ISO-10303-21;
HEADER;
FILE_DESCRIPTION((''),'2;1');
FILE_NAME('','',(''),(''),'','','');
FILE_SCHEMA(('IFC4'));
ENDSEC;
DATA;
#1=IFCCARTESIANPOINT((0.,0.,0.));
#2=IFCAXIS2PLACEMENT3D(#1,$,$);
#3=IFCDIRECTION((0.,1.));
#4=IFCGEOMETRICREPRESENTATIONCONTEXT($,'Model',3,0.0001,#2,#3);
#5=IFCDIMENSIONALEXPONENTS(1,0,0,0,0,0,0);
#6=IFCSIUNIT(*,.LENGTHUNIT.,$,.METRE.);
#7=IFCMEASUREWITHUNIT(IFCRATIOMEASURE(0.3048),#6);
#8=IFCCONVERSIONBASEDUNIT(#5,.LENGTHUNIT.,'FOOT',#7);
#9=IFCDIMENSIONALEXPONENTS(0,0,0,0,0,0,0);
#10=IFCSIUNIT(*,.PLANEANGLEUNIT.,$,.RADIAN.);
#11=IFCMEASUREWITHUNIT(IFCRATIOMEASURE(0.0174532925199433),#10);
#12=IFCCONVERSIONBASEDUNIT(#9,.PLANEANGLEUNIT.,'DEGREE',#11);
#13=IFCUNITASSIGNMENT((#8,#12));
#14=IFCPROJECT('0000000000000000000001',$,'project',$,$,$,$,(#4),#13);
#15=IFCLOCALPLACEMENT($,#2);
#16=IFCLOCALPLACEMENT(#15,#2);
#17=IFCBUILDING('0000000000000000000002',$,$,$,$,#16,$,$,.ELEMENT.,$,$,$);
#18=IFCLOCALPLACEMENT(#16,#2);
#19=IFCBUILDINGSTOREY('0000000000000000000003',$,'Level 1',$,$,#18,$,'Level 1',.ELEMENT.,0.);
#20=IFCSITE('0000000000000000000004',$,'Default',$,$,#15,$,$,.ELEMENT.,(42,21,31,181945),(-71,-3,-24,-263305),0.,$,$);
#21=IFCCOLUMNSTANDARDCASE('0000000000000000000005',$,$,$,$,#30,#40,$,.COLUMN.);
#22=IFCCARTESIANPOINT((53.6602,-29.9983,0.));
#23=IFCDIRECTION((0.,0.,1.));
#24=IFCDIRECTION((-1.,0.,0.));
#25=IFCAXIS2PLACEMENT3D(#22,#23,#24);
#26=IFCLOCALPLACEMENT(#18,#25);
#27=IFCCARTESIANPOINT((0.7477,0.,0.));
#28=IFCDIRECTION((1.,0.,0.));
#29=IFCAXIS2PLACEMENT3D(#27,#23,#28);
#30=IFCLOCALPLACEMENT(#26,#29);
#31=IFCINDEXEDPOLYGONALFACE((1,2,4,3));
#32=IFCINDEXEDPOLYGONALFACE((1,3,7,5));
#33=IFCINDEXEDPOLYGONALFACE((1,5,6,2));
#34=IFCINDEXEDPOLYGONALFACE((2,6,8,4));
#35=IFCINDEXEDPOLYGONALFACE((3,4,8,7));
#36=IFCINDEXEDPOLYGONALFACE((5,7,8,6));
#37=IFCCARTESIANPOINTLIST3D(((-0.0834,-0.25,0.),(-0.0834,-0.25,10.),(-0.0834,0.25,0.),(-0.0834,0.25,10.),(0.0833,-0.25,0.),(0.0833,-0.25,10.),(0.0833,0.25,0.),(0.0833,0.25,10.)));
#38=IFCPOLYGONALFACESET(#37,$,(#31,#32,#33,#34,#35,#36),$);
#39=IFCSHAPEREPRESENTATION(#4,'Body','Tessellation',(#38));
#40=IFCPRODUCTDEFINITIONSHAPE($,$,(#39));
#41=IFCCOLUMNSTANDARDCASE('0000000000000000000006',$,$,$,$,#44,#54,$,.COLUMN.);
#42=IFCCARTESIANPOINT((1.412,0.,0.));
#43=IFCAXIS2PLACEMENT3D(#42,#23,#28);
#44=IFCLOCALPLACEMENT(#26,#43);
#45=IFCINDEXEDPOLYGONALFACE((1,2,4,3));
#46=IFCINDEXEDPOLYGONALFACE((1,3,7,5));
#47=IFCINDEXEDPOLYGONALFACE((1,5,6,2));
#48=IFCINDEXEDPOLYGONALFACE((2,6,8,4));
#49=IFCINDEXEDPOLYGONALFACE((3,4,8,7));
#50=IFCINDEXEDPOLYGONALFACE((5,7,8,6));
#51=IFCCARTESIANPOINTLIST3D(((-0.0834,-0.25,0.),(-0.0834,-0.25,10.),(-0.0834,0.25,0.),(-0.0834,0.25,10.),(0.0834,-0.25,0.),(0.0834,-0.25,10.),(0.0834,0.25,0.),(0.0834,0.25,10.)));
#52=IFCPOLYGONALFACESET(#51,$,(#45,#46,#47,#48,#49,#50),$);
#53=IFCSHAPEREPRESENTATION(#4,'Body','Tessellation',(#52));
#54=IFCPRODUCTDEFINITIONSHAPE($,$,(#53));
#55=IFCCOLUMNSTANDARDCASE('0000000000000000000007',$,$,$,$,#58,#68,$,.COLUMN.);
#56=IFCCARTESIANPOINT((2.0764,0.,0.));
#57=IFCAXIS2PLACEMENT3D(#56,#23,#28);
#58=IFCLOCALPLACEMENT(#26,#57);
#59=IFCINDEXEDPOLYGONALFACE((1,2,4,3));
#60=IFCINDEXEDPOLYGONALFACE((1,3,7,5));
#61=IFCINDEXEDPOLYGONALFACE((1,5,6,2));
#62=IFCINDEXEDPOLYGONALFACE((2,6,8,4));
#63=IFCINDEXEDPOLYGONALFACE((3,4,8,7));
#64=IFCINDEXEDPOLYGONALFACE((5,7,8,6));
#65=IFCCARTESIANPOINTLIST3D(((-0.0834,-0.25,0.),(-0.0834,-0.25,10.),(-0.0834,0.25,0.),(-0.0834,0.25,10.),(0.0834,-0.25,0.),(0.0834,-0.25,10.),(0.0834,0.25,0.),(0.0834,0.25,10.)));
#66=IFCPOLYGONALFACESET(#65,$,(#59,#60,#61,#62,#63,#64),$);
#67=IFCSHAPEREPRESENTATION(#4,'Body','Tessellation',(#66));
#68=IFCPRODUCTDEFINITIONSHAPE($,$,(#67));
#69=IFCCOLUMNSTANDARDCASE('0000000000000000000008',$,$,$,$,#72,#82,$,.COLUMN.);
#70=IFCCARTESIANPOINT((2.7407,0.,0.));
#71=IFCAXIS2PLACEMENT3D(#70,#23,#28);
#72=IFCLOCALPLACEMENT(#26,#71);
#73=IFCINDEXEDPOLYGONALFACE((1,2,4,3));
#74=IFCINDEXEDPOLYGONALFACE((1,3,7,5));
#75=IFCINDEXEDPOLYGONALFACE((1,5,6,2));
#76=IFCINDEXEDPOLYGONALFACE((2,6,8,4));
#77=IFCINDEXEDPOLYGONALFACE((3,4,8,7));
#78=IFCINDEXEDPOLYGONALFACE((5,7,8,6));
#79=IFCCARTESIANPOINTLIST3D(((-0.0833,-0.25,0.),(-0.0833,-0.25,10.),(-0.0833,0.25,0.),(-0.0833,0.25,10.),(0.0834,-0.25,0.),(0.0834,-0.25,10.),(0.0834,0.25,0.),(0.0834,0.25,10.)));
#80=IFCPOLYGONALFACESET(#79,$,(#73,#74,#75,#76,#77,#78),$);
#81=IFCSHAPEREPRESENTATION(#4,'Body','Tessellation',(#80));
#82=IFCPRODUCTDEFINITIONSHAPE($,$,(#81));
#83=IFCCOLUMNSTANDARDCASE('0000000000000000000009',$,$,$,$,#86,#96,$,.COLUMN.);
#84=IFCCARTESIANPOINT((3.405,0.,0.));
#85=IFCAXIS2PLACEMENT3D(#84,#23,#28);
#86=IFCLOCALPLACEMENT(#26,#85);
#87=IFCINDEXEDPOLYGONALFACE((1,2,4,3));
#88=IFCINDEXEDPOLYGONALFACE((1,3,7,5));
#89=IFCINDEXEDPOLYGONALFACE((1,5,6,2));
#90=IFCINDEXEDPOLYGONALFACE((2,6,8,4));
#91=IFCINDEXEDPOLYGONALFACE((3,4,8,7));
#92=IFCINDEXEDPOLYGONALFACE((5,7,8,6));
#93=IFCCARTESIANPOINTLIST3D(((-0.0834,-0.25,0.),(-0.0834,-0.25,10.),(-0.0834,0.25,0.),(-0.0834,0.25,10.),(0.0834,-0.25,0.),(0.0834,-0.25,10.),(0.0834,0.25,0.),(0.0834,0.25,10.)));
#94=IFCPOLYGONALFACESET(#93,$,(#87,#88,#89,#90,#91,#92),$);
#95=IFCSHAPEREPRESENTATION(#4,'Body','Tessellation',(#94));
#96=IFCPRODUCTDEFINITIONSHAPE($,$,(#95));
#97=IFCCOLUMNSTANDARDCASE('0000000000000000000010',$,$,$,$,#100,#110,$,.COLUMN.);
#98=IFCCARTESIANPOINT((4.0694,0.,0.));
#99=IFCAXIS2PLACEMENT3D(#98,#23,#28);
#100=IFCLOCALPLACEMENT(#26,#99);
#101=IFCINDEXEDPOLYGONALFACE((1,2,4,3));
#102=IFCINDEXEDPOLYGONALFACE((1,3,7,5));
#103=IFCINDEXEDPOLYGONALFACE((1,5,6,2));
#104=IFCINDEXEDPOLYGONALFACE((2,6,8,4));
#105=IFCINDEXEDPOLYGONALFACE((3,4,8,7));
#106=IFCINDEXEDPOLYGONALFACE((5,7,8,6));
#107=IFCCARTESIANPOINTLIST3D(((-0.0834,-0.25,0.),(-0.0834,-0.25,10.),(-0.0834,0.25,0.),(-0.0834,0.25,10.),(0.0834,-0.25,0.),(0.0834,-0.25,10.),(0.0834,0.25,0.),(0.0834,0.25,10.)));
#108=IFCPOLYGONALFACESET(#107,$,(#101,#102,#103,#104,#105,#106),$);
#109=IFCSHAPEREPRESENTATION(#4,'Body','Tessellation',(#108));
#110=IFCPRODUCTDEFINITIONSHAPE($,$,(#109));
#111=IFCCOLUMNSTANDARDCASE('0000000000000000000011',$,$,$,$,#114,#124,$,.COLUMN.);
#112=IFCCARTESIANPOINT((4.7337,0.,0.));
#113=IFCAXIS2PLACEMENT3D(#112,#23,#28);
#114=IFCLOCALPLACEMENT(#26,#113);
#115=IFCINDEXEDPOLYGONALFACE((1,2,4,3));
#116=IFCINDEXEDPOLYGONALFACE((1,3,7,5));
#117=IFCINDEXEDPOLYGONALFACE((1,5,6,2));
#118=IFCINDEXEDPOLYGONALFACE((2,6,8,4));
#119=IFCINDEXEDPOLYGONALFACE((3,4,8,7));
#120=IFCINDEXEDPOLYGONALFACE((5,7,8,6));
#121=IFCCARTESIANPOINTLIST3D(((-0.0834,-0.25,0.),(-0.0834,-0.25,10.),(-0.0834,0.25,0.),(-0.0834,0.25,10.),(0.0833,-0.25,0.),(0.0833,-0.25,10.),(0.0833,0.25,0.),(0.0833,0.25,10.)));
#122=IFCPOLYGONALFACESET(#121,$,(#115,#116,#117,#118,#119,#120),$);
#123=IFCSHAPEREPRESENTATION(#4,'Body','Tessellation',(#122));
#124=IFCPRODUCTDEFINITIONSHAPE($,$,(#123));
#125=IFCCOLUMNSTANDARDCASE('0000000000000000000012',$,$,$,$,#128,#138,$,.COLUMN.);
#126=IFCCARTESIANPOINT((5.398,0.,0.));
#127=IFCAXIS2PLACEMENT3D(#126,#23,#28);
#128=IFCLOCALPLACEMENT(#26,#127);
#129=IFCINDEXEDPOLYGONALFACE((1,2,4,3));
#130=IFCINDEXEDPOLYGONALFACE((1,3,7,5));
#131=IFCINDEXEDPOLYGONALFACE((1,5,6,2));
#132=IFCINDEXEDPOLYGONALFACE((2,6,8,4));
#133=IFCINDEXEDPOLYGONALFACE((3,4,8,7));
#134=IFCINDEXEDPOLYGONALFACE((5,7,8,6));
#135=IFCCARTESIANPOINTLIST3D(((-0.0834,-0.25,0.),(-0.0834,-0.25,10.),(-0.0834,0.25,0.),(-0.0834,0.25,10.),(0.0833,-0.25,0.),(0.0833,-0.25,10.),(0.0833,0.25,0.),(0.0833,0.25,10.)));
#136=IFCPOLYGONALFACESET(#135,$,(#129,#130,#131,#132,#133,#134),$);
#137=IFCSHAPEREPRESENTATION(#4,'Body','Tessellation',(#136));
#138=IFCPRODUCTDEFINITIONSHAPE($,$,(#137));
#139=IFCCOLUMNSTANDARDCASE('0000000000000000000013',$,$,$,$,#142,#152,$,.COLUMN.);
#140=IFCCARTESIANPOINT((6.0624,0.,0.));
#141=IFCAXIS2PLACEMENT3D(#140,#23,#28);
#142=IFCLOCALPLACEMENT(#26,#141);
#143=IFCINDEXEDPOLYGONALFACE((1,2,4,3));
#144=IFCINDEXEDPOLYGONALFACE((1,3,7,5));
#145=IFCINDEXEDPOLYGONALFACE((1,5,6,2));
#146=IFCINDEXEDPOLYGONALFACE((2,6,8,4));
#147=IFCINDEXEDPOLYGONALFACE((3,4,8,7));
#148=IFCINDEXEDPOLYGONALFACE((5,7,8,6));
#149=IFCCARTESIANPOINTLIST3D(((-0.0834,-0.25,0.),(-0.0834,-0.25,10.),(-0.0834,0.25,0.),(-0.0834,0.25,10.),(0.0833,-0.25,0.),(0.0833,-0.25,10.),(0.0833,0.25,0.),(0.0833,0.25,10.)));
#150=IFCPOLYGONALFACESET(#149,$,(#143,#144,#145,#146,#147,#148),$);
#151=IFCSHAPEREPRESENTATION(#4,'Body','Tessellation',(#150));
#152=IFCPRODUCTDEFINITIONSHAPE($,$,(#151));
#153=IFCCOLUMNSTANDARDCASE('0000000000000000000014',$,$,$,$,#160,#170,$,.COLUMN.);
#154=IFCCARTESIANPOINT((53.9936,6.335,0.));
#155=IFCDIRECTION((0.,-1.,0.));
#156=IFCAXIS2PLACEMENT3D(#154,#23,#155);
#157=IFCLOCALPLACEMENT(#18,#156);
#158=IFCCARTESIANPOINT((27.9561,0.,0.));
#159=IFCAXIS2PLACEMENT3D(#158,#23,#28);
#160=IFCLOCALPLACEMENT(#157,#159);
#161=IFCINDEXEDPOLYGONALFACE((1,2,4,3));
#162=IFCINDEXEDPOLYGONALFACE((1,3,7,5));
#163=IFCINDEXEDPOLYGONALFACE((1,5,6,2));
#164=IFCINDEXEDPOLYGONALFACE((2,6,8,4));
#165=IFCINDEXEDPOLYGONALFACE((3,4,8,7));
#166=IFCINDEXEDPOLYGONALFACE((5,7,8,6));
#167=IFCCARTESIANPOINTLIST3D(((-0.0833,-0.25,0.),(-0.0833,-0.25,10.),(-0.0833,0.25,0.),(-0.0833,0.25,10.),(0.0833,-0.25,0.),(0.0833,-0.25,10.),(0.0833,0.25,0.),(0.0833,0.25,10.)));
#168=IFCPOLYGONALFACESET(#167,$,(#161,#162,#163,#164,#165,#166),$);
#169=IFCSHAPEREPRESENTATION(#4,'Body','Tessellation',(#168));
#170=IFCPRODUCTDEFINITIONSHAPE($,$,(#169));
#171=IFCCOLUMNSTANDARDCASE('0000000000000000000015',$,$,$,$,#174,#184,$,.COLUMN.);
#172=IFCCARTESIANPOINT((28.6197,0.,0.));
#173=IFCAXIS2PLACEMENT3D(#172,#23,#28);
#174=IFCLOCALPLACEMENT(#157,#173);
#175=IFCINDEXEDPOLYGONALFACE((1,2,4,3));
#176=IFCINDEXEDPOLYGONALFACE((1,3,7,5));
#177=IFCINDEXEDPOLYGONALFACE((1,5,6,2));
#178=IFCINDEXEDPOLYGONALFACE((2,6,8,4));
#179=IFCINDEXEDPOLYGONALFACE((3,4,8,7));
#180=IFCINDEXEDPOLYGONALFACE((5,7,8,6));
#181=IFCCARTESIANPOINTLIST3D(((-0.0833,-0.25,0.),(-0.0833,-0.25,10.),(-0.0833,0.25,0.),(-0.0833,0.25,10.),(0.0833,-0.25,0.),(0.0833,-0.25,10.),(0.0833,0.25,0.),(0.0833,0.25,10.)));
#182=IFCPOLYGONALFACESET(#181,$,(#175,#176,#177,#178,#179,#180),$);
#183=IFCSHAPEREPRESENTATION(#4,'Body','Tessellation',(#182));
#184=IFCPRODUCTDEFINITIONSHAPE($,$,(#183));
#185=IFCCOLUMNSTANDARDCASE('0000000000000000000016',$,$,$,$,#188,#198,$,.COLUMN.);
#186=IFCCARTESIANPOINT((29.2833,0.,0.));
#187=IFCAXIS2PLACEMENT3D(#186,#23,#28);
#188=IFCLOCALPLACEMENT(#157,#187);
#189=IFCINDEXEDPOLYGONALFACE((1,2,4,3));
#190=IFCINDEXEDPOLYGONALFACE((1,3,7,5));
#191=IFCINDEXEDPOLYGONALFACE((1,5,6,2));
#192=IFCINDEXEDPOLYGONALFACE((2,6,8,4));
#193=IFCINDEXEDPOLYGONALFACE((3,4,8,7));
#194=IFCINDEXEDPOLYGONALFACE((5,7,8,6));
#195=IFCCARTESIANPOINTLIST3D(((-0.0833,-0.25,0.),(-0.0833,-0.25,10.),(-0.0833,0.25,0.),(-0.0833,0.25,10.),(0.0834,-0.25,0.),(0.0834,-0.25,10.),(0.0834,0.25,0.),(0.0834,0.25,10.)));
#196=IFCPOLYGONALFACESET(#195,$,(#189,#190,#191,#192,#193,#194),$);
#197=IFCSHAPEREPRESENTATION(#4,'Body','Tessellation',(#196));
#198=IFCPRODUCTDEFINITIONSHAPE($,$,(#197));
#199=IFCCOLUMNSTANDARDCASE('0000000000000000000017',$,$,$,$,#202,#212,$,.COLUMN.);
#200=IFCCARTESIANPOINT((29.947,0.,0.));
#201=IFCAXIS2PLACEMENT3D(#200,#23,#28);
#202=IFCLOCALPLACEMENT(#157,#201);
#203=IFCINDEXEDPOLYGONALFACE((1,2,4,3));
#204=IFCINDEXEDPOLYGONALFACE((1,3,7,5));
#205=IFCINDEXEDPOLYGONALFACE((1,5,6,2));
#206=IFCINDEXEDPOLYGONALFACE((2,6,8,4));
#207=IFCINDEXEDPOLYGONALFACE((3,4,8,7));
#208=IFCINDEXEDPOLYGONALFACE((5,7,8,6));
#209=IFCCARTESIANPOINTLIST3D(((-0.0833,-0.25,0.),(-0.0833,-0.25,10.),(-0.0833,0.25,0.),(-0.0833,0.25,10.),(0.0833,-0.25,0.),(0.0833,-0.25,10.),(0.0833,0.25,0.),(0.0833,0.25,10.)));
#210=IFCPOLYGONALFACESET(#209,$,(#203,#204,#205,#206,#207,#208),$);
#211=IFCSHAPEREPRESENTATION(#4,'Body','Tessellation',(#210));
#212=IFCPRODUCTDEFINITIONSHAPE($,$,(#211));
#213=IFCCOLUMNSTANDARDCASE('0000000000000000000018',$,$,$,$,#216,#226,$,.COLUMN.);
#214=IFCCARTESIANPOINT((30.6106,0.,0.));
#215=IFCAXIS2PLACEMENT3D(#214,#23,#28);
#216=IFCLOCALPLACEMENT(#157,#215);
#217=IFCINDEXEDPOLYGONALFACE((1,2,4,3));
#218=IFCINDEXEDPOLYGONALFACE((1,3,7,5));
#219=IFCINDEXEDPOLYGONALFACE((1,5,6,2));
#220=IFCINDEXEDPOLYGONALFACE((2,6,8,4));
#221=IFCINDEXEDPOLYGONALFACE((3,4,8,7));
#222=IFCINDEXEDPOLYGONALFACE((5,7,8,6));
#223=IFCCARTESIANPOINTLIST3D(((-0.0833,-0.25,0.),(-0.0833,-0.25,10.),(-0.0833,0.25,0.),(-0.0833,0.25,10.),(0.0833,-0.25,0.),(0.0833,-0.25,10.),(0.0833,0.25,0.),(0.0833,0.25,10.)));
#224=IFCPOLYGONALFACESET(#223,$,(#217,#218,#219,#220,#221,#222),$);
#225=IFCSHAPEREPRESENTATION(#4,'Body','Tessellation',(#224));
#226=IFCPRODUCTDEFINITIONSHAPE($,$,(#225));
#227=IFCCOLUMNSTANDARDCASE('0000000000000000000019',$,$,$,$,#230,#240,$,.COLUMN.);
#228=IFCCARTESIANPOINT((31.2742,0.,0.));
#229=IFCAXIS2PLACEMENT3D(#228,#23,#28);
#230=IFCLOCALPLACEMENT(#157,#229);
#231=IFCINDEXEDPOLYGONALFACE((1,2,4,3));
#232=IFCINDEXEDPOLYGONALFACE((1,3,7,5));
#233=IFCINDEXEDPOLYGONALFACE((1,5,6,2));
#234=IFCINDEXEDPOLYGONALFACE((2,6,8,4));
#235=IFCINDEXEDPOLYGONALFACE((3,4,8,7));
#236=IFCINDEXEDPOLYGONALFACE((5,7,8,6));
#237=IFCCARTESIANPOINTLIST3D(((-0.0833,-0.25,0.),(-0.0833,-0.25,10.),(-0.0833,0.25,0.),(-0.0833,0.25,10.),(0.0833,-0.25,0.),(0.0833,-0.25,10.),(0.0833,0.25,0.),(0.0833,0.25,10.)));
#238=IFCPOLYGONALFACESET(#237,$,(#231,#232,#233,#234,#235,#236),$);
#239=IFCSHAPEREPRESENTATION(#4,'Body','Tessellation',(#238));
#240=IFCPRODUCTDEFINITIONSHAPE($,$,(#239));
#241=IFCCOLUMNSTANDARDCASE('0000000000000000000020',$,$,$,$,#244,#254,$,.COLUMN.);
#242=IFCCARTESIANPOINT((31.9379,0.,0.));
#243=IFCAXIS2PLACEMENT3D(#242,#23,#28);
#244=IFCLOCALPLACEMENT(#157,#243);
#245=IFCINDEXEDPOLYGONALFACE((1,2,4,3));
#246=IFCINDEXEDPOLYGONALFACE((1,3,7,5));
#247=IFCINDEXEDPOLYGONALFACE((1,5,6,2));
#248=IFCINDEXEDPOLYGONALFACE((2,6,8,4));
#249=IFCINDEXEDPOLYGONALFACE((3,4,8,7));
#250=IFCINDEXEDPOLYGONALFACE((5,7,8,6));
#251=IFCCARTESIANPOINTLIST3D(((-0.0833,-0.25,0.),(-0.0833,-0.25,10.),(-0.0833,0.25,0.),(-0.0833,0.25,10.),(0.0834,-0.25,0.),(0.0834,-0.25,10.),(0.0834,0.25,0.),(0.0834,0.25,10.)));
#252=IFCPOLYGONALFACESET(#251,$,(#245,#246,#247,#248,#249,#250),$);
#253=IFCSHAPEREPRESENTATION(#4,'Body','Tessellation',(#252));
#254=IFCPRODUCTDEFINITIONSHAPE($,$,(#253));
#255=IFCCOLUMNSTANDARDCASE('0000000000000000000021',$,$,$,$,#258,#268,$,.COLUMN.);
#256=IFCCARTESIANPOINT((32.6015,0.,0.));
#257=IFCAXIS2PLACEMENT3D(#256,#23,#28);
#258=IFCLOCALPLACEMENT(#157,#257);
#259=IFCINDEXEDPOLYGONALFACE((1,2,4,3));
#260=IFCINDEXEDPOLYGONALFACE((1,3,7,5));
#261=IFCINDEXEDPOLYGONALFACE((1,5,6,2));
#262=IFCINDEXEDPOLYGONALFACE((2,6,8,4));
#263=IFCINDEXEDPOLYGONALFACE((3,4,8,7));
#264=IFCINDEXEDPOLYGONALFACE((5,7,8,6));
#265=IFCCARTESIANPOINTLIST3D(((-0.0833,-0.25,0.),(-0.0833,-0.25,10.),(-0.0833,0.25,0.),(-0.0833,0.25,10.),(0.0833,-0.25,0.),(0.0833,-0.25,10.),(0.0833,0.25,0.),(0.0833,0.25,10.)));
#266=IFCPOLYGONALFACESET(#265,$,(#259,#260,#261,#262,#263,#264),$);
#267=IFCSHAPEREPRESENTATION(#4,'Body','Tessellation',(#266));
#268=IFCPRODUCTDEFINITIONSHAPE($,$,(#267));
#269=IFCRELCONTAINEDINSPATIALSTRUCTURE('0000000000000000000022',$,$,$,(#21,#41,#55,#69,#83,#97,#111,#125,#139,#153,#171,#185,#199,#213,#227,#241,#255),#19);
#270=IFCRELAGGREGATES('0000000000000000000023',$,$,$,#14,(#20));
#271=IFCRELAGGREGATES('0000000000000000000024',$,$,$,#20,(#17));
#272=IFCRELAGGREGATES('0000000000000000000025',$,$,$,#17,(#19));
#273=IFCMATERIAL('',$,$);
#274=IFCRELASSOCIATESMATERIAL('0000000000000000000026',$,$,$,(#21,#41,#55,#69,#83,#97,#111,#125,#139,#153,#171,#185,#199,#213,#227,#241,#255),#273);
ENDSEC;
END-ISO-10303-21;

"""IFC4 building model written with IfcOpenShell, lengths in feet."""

from ifc_helpers import new_model, entity, si_unit, converted_unit, direction, frame, origin, place, context, project, spatial, rectangle, extrude, material, element, save


model = new_model("IFC4")

# Units and contexts
model_context = context("Model", 3, precision=0.0001, world=origin(), true_north=direction((0.0, 1.0)))
ifc_project = project(units=[converted_unit("LENGTHUNIT", "FOOT", entity("IfcRatioMeasure", 0.3048), si_unit("LENGTHUNIT", "METRE"), dimensions=[1, 0, 0, 0, 0, 0, 0]), converted_unit("PLANEANGLEUNIT", "DEGREE", entity("IfcRatioMeasure", 0.0174532925199433), si_unit("PLANEANGLEUNIT", "RADIAN"), dimensions=[0, 0, 0, 0, 0, 0, 0])], contexts=[model_context])

# Site, building, storey
site_placement = place(None, origin())
site = spatial("IfcSite", under=ifc_project, at=site_placement, Name="Default", CompositionType="ELEMENT", RefLatitude=(42, 21, 31, 181945), RefLongitude=(-71, -3, -24, -263305), RefElevation=0.0)
building_placement = place(site_placement, origin())
building = spatial("IfcBuilding", under=site, at=building_placement, CompositionType="ELEMENT")
storey_placement = place(building_placement, origin())
storey = spatial("IfcBuildingStorey", under=building, at=storey_placement, Name="Level 1", LongName="Level 1", CompositionType="ELEMENT", Elevation=0.0)

# Columns
ifc_material_1 = material(Name="")
wall_placement = place(storey_placement, frame((53.6602, -29.9983, 0.0), z_axis=(0.0, 0.0, 1.0), x_axis=(-1.0, 0.0, 0.0)))
for number, where, z_axis, x_axis in (
    (1, (0.7477, 0.0, 0.0), (0.0, 0.0, 1.0), (1.0, 0.0, 0.0)),
    (2, (1.412, 0.0, 0.0), (0.0, 0.0, 1.0), (1.0, 0.0, 0.0)),
    (3, (2.0764, 0.0, 0.0), (0.0, 0.0, 1.0), (1.0, 0.0, 0.0)),
    (4, (2.7407, 0.0, 0.0), (0.0, 0.0, 1.0), (1.0, 0.0, 0.0)),
    (5, (3.405, 0.0, 0.0), (0.0, 0.0, 1.0), (1.0, 0.0, 0.0)),
    (6, (4.0694, 0.0, 0.0), (0.0, 0.0, 1.0), (1.0, 0.0, 0.0)),
    (7, (4.7337, 0.0, 0.0), (0.0, 0.0, 1.0), (1.0, 0.0, 0.0)),
    (8, (5.398, 0.0, 0.0), (0.0, 0.0, 1.0), (1.0, 0.0, 0.0)),
    (9, (6.0624, 0.0, 0.0), (0.0, 0.0, 1.0), (1.0, 0.0, 0.0)),
):
    element("IfcColumnStandardCase", number, at=place(wall_placement, frame(where, z_axis=z_axis, x_axis=x_axis)), inside=storey, material=ifc_material_1, PredefinedType="COLUMN", context=model_context, shape_type="SweptSolid", body=[
        extrude(rectangle(XDim=0.1667, YDim=0.5), origin(), (0.0, 0.0, 1.0), 10.0),
    ])
placement = place(storey_placement, frame((53.9936, 6.335, 0.0), z_axis=(0.0, 0.0, 1.0), x_axis=(0.0, -1.0, 0.0)))
for number, where, z_axis, x_axis in (
    (10, (27.9561, 0.0, 0.0), (0.0, 0.0, 1.0), (1.0, 0.0, 0.0)),
    (11, (28.6197, 0.0, 0.0), (0.0, 0.0, 1.0), (1.0, 0.0, 0.0)),
    (12, (29.2833, 0.0, 0.0), (0.0, 0.0, 1.0), (1.0, 0.0, 0.0)),
    (13, (29.947, 0.0, 0.0), (0.0, 0.0, 1.0), (1.0, 0.0, 0.0)),
    (14, (30.6106, 0.0, 0.0), (0.0, 0.0, 1.0), (1.0, 0.0, 0.0)),
    (15, (31.2742, 0.0, 0.0), (0.0, 0.0, 1.0), (1.0, 0.0, 0.0)),
    (16, (31.9379, 0.0, 0.0), (0.0, 0.0, 1.0), (1.0, 0.0, 0.0)),
    (17, (32.6015, 0.0, 0.0), (0.0, 0.0, 1.0), (1.0, 0.0, 0.0)),
):
    element("IfcColumnStandardCase", number, at=place(placement, frame(where, z_axis=z_axis, x_axis=x_axis)), inside=storey, material=ifc_material_1, PredefinedType="COLUMN", context=model_context, shape_type="SweptSolid", body=[
        extrude(rectangle(XDim=0.1667, YDim=0.5), origin(), (0.0, 0.0, 1.0), 10.0),
    ])

save(model, "model.ifc")
